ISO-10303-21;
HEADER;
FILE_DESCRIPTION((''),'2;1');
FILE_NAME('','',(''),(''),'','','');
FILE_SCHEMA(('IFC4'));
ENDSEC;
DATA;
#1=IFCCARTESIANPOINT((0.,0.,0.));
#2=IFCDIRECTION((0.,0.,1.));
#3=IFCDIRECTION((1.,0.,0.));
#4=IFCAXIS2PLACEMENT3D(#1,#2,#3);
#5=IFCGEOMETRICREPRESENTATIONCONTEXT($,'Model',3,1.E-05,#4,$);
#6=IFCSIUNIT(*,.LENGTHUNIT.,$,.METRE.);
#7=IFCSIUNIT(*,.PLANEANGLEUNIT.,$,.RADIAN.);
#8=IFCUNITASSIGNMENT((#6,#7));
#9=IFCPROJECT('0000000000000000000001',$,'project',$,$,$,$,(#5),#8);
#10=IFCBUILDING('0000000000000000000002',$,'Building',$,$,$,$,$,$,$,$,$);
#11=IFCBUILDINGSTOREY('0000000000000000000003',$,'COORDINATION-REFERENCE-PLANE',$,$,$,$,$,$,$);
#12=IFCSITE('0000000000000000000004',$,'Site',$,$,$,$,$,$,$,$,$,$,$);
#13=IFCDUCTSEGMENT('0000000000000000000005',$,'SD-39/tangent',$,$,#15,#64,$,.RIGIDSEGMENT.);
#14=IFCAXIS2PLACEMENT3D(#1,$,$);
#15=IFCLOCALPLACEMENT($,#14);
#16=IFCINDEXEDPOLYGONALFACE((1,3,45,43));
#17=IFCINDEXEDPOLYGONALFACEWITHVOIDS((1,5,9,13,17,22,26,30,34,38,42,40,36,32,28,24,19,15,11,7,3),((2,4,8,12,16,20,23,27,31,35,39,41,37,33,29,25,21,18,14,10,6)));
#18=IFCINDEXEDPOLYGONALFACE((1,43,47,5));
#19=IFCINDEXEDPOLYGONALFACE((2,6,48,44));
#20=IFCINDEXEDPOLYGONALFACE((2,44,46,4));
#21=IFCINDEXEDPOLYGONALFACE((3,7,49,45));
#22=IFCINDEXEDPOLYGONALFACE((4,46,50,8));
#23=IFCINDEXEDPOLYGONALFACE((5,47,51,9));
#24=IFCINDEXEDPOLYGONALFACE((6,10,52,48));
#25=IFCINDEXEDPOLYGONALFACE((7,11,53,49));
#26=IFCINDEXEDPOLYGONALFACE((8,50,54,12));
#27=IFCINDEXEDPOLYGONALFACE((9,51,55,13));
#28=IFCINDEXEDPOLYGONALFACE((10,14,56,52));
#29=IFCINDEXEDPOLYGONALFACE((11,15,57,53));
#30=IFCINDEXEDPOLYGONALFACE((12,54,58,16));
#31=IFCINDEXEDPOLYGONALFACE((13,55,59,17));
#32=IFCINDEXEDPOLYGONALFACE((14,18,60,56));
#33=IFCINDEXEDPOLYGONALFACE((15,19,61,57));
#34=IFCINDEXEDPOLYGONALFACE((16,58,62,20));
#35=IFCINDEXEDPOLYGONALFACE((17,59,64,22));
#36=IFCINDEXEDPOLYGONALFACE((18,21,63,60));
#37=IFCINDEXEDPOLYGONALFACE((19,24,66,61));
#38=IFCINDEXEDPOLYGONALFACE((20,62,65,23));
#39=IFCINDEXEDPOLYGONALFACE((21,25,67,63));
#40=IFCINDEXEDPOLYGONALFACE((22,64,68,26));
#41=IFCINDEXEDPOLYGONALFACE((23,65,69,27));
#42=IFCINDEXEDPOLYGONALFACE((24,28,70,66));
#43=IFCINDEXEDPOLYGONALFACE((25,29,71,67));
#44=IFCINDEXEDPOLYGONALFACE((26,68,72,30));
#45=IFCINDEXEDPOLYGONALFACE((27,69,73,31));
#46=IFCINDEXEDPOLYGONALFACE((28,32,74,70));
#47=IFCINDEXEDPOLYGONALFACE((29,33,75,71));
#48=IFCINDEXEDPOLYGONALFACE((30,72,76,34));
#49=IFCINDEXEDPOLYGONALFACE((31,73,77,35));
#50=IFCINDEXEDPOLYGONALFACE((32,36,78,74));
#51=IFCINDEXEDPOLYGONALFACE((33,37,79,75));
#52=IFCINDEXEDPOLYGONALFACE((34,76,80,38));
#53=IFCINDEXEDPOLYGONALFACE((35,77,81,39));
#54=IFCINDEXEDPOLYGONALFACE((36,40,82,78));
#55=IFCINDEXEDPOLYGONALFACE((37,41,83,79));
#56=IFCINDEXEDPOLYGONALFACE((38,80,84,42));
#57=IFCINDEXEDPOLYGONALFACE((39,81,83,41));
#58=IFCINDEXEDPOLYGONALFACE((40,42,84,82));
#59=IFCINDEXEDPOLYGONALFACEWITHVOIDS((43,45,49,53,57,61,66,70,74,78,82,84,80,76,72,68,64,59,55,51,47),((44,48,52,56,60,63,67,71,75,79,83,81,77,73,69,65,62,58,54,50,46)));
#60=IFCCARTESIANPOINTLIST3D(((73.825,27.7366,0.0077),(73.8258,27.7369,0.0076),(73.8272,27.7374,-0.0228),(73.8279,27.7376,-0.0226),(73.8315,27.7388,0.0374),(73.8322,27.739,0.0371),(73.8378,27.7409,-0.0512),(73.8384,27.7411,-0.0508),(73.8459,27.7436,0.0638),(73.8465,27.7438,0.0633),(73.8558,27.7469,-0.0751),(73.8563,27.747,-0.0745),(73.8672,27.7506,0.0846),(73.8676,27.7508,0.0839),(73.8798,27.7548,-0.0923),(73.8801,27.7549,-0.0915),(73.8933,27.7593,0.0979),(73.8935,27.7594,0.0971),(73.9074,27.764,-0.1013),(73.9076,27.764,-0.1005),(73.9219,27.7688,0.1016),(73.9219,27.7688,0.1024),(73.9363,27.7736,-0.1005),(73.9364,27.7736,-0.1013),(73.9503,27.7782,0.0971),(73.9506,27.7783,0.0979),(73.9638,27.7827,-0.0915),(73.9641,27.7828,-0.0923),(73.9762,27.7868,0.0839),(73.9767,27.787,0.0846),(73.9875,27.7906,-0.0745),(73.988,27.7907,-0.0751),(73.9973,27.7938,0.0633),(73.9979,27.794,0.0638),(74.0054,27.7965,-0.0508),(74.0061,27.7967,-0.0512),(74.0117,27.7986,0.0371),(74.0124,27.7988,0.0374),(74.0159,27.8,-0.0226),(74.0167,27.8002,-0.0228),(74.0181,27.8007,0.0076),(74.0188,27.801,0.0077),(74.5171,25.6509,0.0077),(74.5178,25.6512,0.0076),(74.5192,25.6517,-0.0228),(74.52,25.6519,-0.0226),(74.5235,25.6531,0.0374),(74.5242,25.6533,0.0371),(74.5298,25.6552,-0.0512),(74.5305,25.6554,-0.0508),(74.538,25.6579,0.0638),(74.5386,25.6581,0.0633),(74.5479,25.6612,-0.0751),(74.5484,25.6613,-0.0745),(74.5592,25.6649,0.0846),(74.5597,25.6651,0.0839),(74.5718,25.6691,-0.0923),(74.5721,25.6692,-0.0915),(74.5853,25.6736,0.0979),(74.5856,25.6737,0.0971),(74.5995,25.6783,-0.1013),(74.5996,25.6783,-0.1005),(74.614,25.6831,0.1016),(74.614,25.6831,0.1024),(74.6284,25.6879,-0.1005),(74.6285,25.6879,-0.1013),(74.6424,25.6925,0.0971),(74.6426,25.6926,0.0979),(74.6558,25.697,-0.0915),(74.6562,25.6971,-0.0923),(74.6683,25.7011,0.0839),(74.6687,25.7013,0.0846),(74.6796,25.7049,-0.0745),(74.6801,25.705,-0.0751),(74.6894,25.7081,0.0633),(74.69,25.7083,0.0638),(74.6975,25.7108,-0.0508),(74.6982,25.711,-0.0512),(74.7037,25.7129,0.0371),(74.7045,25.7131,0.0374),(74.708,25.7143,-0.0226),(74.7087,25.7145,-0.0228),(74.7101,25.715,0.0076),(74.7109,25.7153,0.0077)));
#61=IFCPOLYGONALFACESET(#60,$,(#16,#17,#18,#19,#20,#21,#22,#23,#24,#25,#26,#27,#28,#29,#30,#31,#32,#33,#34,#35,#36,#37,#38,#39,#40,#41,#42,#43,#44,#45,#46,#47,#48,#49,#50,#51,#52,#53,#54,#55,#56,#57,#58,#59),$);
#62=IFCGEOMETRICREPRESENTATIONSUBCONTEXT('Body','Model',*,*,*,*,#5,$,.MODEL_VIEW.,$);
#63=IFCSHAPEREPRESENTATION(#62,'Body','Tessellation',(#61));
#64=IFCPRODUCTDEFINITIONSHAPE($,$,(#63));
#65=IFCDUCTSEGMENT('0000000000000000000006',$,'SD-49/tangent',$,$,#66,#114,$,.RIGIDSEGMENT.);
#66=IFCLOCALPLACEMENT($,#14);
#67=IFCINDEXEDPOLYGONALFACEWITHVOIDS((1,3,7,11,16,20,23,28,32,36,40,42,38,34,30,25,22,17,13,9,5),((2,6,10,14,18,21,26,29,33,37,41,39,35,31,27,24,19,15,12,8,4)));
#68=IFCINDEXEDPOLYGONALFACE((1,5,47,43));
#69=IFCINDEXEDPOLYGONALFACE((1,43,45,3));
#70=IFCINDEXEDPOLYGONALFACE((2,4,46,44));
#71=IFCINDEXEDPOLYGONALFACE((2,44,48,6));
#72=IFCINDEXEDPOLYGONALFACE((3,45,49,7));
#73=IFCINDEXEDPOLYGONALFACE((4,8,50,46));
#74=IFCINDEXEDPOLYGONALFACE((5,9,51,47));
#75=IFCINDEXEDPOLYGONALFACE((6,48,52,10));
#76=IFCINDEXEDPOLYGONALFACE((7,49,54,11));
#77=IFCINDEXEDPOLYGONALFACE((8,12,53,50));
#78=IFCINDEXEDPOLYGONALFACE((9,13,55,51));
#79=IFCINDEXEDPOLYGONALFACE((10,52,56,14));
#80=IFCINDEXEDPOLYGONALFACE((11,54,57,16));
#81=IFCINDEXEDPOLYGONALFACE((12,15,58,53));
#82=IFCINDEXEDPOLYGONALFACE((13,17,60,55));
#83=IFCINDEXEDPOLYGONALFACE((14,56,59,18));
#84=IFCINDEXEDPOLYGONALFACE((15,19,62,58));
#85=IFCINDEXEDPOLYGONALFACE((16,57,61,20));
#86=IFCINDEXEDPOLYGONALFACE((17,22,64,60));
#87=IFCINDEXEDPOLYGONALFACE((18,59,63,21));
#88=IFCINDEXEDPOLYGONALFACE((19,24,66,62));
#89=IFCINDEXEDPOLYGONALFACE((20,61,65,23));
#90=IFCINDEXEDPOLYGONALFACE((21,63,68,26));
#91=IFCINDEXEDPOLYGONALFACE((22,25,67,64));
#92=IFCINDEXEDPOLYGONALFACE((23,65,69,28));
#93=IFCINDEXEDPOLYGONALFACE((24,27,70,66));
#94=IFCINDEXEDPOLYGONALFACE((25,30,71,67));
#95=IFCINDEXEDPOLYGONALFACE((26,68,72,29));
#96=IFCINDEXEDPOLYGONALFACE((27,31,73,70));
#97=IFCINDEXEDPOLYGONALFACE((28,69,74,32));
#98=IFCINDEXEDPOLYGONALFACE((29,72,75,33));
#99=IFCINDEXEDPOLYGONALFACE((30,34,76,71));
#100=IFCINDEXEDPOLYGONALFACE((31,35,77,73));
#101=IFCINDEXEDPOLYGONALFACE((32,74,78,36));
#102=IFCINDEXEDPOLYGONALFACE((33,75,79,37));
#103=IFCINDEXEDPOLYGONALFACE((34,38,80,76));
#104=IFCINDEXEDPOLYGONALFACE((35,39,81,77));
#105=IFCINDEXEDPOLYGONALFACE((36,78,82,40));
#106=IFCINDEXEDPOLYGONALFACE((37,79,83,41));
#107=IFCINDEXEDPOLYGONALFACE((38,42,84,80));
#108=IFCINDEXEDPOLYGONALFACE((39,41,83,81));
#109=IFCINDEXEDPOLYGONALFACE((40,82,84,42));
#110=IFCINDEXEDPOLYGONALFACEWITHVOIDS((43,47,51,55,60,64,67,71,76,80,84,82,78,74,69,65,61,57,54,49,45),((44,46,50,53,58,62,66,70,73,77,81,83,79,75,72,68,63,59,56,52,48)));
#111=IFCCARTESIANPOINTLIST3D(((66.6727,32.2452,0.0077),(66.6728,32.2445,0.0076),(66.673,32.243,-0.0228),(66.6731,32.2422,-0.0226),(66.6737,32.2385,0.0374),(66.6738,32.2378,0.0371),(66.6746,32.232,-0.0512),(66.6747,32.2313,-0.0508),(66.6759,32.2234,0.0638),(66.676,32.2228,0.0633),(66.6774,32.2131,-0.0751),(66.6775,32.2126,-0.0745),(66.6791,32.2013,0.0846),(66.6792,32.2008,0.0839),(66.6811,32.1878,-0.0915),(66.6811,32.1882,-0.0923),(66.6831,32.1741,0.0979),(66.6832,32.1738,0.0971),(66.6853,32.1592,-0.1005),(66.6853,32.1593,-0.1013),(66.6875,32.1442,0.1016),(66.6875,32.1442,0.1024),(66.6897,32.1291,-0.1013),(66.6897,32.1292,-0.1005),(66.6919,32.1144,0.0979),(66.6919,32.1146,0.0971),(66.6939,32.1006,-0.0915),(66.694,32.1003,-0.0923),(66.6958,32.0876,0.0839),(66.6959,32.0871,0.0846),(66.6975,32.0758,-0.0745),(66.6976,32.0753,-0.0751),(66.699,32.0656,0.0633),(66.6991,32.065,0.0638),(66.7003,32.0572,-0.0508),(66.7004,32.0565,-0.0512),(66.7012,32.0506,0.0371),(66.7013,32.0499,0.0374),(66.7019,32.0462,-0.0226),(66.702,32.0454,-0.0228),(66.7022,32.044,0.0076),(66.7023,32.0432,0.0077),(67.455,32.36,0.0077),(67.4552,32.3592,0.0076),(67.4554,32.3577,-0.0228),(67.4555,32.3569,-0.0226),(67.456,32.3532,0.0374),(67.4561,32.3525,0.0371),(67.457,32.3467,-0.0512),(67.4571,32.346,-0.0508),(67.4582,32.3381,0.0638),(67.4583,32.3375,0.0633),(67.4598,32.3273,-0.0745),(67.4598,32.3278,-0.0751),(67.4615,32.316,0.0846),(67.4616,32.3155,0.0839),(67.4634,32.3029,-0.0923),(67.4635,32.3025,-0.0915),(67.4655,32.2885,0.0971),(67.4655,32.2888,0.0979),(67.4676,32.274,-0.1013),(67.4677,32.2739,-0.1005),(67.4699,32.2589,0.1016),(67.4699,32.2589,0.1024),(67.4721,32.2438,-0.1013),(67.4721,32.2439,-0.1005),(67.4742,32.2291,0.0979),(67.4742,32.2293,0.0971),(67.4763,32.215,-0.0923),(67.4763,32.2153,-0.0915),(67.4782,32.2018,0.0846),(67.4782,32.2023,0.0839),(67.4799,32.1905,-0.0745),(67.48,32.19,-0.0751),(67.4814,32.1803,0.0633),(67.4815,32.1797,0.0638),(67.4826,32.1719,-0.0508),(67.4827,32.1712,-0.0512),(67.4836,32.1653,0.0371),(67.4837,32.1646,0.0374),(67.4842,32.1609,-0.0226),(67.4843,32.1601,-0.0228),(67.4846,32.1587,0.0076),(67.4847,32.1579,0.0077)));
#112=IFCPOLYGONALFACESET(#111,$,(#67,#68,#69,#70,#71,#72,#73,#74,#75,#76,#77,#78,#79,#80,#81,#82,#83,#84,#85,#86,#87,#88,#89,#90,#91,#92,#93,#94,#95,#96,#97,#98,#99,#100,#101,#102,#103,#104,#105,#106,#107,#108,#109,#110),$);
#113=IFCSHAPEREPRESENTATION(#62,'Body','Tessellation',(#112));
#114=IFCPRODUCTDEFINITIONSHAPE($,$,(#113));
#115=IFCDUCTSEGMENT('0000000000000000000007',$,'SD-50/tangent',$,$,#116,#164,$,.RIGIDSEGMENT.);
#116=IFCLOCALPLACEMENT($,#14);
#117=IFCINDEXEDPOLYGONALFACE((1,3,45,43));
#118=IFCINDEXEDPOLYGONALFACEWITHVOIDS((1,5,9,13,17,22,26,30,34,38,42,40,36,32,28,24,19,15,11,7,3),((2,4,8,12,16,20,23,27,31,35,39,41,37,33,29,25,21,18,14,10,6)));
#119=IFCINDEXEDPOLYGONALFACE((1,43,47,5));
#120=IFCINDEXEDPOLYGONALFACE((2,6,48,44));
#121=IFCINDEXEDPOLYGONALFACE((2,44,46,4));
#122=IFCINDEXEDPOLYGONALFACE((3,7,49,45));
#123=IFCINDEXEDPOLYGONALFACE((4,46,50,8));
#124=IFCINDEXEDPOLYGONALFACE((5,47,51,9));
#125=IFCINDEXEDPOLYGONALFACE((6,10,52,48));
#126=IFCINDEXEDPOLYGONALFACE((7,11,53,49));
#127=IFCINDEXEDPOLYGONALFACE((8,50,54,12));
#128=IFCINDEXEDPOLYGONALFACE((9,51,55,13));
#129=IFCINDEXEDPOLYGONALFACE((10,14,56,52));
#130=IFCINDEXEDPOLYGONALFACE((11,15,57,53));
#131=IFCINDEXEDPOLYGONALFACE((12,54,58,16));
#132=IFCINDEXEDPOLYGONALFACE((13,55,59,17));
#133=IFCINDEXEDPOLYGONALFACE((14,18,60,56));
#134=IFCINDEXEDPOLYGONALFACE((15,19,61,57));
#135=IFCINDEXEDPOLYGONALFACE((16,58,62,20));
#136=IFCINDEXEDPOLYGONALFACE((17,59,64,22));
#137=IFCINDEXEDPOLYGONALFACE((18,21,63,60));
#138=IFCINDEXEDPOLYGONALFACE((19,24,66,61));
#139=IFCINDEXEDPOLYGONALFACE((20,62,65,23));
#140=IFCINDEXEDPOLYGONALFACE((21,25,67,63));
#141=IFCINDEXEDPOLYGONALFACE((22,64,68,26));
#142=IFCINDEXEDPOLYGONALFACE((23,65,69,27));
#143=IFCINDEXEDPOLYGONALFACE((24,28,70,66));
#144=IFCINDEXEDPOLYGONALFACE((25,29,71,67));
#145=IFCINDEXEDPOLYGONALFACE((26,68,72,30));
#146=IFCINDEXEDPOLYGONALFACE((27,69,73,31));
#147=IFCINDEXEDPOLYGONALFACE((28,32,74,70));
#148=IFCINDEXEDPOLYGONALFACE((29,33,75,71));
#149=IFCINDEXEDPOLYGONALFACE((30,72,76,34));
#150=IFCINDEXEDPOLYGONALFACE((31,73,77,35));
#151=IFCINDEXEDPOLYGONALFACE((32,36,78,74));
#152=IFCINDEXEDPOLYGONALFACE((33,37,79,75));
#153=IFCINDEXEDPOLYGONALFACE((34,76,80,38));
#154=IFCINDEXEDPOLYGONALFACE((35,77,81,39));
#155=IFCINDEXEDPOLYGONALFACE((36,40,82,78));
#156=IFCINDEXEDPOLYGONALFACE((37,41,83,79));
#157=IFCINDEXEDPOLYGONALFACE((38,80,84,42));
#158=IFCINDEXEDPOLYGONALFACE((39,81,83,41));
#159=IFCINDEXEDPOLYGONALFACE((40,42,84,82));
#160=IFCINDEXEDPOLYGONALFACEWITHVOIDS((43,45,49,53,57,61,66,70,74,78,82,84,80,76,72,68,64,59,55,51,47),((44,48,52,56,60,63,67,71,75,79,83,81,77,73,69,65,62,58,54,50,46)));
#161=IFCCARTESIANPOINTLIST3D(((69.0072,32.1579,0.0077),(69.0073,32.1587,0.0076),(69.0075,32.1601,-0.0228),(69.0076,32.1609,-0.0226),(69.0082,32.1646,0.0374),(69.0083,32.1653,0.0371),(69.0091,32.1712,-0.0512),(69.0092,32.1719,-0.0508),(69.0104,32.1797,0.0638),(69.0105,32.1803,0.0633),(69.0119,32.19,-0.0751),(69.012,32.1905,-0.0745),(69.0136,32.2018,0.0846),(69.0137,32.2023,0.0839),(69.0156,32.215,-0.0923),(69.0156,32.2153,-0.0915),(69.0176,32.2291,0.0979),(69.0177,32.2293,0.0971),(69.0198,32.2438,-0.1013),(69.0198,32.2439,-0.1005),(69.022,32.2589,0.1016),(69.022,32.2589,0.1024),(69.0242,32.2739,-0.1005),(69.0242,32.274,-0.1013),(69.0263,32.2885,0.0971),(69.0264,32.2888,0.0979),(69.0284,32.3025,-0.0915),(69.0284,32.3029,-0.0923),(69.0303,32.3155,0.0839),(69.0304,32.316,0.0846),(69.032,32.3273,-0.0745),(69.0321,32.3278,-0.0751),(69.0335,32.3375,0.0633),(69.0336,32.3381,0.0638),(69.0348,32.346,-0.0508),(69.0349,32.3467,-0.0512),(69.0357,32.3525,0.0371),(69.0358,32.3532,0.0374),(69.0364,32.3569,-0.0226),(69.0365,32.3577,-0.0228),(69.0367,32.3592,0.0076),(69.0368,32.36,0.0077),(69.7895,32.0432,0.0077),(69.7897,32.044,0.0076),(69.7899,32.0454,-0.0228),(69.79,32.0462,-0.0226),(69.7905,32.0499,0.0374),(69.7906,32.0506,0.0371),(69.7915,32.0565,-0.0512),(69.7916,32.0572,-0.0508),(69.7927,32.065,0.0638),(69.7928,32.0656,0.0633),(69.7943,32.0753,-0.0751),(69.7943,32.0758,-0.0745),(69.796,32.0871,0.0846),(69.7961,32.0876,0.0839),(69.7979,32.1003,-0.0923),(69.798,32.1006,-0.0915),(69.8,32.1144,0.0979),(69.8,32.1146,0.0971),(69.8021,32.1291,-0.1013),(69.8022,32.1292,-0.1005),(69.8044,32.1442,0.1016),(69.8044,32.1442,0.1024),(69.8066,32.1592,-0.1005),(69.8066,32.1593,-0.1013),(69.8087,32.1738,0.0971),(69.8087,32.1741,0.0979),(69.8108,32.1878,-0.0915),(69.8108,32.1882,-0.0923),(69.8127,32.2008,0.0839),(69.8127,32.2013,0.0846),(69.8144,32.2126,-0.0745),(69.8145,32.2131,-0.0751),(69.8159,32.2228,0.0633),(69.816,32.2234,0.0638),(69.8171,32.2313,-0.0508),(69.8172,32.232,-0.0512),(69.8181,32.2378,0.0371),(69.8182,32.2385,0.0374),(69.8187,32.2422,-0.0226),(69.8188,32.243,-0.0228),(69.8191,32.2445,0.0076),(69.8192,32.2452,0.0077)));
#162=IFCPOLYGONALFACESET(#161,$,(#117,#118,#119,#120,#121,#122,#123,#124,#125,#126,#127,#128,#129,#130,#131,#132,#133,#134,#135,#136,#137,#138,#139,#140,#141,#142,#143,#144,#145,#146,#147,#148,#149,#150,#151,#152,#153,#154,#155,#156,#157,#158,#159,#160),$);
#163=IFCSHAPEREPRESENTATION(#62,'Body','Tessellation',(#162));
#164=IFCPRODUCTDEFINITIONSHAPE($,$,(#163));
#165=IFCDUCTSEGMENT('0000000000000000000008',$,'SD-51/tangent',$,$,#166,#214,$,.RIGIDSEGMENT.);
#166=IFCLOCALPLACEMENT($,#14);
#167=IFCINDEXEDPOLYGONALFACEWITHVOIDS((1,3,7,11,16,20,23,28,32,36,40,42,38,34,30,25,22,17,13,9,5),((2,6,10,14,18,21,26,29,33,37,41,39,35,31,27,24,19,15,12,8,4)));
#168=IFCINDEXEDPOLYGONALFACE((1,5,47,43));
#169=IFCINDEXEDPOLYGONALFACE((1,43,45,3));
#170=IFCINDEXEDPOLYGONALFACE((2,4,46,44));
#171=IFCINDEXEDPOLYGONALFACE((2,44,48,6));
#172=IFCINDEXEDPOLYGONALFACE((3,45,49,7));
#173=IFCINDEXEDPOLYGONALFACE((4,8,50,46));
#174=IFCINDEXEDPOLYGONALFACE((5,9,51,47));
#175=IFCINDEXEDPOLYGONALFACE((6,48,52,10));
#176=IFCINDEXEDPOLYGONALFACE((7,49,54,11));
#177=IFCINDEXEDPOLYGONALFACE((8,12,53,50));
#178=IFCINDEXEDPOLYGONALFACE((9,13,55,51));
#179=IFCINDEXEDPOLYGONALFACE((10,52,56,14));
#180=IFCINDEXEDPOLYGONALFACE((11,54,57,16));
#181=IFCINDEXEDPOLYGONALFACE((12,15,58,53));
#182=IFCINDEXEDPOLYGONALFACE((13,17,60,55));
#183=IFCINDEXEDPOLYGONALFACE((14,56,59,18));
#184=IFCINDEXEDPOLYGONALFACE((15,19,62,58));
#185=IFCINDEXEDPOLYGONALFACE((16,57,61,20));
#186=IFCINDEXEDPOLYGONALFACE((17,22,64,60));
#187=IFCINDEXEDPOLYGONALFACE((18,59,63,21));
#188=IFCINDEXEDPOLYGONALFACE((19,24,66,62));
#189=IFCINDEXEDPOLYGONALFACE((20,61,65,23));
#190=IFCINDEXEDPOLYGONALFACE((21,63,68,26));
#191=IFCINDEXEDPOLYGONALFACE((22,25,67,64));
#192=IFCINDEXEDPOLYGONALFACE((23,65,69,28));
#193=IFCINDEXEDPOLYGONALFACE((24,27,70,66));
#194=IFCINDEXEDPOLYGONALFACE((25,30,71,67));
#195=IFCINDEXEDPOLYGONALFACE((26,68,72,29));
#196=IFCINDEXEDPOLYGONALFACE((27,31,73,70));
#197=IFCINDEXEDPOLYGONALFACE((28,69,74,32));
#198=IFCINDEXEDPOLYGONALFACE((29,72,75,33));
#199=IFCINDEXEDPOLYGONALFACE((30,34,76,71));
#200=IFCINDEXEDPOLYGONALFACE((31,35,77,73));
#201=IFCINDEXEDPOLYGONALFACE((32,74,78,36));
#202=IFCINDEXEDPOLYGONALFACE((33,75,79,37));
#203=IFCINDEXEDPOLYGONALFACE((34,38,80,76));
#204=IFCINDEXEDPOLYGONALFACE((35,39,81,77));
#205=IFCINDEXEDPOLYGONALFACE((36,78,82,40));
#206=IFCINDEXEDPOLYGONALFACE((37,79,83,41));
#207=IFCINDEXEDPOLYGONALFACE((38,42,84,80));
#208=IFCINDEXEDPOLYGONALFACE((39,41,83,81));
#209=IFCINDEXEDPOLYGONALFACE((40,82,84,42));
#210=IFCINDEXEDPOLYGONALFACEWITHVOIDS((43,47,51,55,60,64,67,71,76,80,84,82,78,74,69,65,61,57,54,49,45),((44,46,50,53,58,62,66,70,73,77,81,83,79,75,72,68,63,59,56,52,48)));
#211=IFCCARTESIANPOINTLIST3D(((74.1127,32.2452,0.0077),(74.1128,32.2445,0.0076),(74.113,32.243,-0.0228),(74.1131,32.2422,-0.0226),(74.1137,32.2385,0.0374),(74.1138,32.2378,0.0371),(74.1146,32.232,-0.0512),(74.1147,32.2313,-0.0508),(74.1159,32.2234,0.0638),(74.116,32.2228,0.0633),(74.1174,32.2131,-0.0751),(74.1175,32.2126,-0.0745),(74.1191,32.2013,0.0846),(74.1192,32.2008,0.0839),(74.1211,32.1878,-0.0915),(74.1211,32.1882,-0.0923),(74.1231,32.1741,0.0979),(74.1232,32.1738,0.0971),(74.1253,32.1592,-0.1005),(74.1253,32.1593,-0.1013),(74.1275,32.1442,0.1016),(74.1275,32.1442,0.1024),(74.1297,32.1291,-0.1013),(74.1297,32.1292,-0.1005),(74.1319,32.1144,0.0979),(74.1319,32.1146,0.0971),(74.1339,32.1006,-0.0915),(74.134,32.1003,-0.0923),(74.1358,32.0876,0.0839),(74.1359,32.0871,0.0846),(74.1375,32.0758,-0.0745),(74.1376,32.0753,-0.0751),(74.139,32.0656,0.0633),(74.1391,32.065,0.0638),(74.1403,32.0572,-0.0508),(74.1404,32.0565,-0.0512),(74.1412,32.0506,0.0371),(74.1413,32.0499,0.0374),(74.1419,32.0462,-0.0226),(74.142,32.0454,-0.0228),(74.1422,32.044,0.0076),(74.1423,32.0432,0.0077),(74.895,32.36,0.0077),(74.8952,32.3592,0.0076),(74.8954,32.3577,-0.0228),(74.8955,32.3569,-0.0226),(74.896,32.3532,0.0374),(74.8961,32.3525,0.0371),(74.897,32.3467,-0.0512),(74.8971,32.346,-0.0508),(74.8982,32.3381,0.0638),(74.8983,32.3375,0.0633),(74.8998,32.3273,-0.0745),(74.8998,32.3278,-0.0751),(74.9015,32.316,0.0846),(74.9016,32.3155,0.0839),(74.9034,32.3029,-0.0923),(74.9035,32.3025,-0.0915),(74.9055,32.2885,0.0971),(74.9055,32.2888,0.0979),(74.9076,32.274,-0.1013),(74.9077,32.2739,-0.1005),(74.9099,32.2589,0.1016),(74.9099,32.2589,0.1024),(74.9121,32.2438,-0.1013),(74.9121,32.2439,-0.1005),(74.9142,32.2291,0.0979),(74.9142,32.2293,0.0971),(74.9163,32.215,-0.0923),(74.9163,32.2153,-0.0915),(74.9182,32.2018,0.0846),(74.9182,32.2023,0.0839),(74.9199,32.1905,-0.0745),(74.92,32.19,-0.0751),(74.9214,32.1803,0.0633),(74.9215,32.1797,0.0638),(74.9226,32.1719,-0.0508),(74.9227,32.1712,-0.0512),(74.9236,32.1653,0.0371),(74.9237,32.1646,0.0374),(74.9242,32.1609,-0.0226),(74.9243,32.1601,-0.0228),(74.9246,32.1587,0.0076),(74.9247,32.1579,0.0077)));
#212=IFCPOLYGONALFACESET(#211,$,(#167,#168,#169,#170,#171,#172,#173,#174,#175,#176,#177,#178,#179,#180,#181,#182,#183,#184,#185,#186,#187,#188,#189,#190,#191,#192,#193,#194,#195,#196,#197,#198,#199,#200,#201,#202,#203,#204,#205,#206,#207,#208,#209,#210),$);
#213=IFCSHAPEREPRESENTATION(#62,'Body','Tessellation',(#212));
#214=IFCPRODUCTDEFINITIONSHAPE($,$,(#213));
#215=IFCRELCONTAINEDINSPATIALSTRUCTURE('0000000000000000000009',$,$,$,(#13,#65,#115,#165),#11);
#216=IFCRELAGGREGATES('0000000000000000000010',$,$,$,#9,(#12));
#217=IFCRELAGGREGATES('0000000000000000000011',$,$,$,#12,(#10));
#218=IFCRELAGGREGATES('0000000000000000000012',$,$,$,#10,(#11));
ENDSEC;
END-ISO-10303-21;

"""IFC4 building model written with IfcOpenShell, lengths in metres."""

from ifc_helpers import new_model, si_unit, frame, origin_with_axes, place, context, subcontext, project, spatial, hollow_circle, extrude, element, save


model = new_model("IFC4")

# Units and contexts
model_context = context("Model", 3, precision=1e-05, world=origin_with_axes())
body_context_1 = subcontext(model_context, "Body", "Model", "MODEL_VIEW")
ifc_project = project(units=[si_unit("LENGTHUNIT", "METRE"), si_unit("PLANEANGLEUNIT", "RADIAN")], contexts=[model_context])

# Site, building, storey
site = spatial("IfcSite", under=ifc_project, Name="Site")
building = spatial("IfcBuilding", under=site, Name="Building")
storey = spatial("IfcBuildingStorey", under=building, Name="COORDINATION-REFERENCE-PLANE")

# Duct segment
duct_segment_1_placement = place(None, frame((74.614, 25.6831, 0.0), z_axis=(-0.314929, 0.949115, 0.0), x_axis=(0.0, 0.0, 1.0)))
element("IfcDuctSegment", 1, at=duct_segment_1_placement, inside=storey, Name="SD-39/tangent", PredefinedType="RIGIDSEGMENT", context=body_context_1, shape_type="SweptSolid", body=[
    extrude(hollow_circle(Radius=0.1024, WallThickness=0.0008), origin_with_axes(), (0.0, 0.0, 1.0), 2.1975),
])

# Duct segment
duct_segment_2_placement = place(None, frame((67.4699, 32.2589, 0.0), z_axis=(-0.989423, -0.145062, 0.0), x_axis=(0.0, 0.0, 1.0)))
element("IfcDuctSegment", 2, at=duct_segment_2_placement, inside=storey, Name="SD-49/tangent", PredefinedType="RIGIDSEGMENT", context=body_context_1, shape_type="SweptSolid", body=[
    extrude(hollow_circle(Radius=0.1024, WallThickness=0.0008), origin_with_axes(), (0.0, 0.0, 1.0), 0.7907),
])

# Duct segment
duct_segment_3_placement = place(None, frame((69.022, 32.2589, 0.0), z_axis=(0.989423, -0.145062, 0.0), x_axis=(0.0, 0.0, 1.0)))
element("IfcDuctSegment", 3, at=duct_segment_3_placement, inside=storey, Name="SD-50/tangent", PredefinedType="RIGIDSEGMENT", context=body_context_1, shape_type="SweptSolid", body=[
    extrude(hollow_circle(Radius=0.1024, WallThickness=0.0008), origin_with_axes(), (0.0, 0.0, 1.0), 0.7907),
])

# Duct segment
duct_segment_4_placement = place(None, frame((74.9099, 32.2589, 0.0), z_axis=(-0.989423, -0.145062, 0.0), x_axis=(0.0, 0.0, 1.0)))
element("IfcDuctSegment", 4, at=duct_segment_4_placement, inside=storey, Name="SD-51/tangent", PredefinedType="RIGIDSEGMENT", context=body_context_1, shape_type="SweptSolid", body=[
    extrude(hollow_circle(Radius=0.1024, WallThickness=0.0008), origin_with_axes(), (0.0, 0.0, 1.0), 0.7907),
])

save(model, "model.ifc")
